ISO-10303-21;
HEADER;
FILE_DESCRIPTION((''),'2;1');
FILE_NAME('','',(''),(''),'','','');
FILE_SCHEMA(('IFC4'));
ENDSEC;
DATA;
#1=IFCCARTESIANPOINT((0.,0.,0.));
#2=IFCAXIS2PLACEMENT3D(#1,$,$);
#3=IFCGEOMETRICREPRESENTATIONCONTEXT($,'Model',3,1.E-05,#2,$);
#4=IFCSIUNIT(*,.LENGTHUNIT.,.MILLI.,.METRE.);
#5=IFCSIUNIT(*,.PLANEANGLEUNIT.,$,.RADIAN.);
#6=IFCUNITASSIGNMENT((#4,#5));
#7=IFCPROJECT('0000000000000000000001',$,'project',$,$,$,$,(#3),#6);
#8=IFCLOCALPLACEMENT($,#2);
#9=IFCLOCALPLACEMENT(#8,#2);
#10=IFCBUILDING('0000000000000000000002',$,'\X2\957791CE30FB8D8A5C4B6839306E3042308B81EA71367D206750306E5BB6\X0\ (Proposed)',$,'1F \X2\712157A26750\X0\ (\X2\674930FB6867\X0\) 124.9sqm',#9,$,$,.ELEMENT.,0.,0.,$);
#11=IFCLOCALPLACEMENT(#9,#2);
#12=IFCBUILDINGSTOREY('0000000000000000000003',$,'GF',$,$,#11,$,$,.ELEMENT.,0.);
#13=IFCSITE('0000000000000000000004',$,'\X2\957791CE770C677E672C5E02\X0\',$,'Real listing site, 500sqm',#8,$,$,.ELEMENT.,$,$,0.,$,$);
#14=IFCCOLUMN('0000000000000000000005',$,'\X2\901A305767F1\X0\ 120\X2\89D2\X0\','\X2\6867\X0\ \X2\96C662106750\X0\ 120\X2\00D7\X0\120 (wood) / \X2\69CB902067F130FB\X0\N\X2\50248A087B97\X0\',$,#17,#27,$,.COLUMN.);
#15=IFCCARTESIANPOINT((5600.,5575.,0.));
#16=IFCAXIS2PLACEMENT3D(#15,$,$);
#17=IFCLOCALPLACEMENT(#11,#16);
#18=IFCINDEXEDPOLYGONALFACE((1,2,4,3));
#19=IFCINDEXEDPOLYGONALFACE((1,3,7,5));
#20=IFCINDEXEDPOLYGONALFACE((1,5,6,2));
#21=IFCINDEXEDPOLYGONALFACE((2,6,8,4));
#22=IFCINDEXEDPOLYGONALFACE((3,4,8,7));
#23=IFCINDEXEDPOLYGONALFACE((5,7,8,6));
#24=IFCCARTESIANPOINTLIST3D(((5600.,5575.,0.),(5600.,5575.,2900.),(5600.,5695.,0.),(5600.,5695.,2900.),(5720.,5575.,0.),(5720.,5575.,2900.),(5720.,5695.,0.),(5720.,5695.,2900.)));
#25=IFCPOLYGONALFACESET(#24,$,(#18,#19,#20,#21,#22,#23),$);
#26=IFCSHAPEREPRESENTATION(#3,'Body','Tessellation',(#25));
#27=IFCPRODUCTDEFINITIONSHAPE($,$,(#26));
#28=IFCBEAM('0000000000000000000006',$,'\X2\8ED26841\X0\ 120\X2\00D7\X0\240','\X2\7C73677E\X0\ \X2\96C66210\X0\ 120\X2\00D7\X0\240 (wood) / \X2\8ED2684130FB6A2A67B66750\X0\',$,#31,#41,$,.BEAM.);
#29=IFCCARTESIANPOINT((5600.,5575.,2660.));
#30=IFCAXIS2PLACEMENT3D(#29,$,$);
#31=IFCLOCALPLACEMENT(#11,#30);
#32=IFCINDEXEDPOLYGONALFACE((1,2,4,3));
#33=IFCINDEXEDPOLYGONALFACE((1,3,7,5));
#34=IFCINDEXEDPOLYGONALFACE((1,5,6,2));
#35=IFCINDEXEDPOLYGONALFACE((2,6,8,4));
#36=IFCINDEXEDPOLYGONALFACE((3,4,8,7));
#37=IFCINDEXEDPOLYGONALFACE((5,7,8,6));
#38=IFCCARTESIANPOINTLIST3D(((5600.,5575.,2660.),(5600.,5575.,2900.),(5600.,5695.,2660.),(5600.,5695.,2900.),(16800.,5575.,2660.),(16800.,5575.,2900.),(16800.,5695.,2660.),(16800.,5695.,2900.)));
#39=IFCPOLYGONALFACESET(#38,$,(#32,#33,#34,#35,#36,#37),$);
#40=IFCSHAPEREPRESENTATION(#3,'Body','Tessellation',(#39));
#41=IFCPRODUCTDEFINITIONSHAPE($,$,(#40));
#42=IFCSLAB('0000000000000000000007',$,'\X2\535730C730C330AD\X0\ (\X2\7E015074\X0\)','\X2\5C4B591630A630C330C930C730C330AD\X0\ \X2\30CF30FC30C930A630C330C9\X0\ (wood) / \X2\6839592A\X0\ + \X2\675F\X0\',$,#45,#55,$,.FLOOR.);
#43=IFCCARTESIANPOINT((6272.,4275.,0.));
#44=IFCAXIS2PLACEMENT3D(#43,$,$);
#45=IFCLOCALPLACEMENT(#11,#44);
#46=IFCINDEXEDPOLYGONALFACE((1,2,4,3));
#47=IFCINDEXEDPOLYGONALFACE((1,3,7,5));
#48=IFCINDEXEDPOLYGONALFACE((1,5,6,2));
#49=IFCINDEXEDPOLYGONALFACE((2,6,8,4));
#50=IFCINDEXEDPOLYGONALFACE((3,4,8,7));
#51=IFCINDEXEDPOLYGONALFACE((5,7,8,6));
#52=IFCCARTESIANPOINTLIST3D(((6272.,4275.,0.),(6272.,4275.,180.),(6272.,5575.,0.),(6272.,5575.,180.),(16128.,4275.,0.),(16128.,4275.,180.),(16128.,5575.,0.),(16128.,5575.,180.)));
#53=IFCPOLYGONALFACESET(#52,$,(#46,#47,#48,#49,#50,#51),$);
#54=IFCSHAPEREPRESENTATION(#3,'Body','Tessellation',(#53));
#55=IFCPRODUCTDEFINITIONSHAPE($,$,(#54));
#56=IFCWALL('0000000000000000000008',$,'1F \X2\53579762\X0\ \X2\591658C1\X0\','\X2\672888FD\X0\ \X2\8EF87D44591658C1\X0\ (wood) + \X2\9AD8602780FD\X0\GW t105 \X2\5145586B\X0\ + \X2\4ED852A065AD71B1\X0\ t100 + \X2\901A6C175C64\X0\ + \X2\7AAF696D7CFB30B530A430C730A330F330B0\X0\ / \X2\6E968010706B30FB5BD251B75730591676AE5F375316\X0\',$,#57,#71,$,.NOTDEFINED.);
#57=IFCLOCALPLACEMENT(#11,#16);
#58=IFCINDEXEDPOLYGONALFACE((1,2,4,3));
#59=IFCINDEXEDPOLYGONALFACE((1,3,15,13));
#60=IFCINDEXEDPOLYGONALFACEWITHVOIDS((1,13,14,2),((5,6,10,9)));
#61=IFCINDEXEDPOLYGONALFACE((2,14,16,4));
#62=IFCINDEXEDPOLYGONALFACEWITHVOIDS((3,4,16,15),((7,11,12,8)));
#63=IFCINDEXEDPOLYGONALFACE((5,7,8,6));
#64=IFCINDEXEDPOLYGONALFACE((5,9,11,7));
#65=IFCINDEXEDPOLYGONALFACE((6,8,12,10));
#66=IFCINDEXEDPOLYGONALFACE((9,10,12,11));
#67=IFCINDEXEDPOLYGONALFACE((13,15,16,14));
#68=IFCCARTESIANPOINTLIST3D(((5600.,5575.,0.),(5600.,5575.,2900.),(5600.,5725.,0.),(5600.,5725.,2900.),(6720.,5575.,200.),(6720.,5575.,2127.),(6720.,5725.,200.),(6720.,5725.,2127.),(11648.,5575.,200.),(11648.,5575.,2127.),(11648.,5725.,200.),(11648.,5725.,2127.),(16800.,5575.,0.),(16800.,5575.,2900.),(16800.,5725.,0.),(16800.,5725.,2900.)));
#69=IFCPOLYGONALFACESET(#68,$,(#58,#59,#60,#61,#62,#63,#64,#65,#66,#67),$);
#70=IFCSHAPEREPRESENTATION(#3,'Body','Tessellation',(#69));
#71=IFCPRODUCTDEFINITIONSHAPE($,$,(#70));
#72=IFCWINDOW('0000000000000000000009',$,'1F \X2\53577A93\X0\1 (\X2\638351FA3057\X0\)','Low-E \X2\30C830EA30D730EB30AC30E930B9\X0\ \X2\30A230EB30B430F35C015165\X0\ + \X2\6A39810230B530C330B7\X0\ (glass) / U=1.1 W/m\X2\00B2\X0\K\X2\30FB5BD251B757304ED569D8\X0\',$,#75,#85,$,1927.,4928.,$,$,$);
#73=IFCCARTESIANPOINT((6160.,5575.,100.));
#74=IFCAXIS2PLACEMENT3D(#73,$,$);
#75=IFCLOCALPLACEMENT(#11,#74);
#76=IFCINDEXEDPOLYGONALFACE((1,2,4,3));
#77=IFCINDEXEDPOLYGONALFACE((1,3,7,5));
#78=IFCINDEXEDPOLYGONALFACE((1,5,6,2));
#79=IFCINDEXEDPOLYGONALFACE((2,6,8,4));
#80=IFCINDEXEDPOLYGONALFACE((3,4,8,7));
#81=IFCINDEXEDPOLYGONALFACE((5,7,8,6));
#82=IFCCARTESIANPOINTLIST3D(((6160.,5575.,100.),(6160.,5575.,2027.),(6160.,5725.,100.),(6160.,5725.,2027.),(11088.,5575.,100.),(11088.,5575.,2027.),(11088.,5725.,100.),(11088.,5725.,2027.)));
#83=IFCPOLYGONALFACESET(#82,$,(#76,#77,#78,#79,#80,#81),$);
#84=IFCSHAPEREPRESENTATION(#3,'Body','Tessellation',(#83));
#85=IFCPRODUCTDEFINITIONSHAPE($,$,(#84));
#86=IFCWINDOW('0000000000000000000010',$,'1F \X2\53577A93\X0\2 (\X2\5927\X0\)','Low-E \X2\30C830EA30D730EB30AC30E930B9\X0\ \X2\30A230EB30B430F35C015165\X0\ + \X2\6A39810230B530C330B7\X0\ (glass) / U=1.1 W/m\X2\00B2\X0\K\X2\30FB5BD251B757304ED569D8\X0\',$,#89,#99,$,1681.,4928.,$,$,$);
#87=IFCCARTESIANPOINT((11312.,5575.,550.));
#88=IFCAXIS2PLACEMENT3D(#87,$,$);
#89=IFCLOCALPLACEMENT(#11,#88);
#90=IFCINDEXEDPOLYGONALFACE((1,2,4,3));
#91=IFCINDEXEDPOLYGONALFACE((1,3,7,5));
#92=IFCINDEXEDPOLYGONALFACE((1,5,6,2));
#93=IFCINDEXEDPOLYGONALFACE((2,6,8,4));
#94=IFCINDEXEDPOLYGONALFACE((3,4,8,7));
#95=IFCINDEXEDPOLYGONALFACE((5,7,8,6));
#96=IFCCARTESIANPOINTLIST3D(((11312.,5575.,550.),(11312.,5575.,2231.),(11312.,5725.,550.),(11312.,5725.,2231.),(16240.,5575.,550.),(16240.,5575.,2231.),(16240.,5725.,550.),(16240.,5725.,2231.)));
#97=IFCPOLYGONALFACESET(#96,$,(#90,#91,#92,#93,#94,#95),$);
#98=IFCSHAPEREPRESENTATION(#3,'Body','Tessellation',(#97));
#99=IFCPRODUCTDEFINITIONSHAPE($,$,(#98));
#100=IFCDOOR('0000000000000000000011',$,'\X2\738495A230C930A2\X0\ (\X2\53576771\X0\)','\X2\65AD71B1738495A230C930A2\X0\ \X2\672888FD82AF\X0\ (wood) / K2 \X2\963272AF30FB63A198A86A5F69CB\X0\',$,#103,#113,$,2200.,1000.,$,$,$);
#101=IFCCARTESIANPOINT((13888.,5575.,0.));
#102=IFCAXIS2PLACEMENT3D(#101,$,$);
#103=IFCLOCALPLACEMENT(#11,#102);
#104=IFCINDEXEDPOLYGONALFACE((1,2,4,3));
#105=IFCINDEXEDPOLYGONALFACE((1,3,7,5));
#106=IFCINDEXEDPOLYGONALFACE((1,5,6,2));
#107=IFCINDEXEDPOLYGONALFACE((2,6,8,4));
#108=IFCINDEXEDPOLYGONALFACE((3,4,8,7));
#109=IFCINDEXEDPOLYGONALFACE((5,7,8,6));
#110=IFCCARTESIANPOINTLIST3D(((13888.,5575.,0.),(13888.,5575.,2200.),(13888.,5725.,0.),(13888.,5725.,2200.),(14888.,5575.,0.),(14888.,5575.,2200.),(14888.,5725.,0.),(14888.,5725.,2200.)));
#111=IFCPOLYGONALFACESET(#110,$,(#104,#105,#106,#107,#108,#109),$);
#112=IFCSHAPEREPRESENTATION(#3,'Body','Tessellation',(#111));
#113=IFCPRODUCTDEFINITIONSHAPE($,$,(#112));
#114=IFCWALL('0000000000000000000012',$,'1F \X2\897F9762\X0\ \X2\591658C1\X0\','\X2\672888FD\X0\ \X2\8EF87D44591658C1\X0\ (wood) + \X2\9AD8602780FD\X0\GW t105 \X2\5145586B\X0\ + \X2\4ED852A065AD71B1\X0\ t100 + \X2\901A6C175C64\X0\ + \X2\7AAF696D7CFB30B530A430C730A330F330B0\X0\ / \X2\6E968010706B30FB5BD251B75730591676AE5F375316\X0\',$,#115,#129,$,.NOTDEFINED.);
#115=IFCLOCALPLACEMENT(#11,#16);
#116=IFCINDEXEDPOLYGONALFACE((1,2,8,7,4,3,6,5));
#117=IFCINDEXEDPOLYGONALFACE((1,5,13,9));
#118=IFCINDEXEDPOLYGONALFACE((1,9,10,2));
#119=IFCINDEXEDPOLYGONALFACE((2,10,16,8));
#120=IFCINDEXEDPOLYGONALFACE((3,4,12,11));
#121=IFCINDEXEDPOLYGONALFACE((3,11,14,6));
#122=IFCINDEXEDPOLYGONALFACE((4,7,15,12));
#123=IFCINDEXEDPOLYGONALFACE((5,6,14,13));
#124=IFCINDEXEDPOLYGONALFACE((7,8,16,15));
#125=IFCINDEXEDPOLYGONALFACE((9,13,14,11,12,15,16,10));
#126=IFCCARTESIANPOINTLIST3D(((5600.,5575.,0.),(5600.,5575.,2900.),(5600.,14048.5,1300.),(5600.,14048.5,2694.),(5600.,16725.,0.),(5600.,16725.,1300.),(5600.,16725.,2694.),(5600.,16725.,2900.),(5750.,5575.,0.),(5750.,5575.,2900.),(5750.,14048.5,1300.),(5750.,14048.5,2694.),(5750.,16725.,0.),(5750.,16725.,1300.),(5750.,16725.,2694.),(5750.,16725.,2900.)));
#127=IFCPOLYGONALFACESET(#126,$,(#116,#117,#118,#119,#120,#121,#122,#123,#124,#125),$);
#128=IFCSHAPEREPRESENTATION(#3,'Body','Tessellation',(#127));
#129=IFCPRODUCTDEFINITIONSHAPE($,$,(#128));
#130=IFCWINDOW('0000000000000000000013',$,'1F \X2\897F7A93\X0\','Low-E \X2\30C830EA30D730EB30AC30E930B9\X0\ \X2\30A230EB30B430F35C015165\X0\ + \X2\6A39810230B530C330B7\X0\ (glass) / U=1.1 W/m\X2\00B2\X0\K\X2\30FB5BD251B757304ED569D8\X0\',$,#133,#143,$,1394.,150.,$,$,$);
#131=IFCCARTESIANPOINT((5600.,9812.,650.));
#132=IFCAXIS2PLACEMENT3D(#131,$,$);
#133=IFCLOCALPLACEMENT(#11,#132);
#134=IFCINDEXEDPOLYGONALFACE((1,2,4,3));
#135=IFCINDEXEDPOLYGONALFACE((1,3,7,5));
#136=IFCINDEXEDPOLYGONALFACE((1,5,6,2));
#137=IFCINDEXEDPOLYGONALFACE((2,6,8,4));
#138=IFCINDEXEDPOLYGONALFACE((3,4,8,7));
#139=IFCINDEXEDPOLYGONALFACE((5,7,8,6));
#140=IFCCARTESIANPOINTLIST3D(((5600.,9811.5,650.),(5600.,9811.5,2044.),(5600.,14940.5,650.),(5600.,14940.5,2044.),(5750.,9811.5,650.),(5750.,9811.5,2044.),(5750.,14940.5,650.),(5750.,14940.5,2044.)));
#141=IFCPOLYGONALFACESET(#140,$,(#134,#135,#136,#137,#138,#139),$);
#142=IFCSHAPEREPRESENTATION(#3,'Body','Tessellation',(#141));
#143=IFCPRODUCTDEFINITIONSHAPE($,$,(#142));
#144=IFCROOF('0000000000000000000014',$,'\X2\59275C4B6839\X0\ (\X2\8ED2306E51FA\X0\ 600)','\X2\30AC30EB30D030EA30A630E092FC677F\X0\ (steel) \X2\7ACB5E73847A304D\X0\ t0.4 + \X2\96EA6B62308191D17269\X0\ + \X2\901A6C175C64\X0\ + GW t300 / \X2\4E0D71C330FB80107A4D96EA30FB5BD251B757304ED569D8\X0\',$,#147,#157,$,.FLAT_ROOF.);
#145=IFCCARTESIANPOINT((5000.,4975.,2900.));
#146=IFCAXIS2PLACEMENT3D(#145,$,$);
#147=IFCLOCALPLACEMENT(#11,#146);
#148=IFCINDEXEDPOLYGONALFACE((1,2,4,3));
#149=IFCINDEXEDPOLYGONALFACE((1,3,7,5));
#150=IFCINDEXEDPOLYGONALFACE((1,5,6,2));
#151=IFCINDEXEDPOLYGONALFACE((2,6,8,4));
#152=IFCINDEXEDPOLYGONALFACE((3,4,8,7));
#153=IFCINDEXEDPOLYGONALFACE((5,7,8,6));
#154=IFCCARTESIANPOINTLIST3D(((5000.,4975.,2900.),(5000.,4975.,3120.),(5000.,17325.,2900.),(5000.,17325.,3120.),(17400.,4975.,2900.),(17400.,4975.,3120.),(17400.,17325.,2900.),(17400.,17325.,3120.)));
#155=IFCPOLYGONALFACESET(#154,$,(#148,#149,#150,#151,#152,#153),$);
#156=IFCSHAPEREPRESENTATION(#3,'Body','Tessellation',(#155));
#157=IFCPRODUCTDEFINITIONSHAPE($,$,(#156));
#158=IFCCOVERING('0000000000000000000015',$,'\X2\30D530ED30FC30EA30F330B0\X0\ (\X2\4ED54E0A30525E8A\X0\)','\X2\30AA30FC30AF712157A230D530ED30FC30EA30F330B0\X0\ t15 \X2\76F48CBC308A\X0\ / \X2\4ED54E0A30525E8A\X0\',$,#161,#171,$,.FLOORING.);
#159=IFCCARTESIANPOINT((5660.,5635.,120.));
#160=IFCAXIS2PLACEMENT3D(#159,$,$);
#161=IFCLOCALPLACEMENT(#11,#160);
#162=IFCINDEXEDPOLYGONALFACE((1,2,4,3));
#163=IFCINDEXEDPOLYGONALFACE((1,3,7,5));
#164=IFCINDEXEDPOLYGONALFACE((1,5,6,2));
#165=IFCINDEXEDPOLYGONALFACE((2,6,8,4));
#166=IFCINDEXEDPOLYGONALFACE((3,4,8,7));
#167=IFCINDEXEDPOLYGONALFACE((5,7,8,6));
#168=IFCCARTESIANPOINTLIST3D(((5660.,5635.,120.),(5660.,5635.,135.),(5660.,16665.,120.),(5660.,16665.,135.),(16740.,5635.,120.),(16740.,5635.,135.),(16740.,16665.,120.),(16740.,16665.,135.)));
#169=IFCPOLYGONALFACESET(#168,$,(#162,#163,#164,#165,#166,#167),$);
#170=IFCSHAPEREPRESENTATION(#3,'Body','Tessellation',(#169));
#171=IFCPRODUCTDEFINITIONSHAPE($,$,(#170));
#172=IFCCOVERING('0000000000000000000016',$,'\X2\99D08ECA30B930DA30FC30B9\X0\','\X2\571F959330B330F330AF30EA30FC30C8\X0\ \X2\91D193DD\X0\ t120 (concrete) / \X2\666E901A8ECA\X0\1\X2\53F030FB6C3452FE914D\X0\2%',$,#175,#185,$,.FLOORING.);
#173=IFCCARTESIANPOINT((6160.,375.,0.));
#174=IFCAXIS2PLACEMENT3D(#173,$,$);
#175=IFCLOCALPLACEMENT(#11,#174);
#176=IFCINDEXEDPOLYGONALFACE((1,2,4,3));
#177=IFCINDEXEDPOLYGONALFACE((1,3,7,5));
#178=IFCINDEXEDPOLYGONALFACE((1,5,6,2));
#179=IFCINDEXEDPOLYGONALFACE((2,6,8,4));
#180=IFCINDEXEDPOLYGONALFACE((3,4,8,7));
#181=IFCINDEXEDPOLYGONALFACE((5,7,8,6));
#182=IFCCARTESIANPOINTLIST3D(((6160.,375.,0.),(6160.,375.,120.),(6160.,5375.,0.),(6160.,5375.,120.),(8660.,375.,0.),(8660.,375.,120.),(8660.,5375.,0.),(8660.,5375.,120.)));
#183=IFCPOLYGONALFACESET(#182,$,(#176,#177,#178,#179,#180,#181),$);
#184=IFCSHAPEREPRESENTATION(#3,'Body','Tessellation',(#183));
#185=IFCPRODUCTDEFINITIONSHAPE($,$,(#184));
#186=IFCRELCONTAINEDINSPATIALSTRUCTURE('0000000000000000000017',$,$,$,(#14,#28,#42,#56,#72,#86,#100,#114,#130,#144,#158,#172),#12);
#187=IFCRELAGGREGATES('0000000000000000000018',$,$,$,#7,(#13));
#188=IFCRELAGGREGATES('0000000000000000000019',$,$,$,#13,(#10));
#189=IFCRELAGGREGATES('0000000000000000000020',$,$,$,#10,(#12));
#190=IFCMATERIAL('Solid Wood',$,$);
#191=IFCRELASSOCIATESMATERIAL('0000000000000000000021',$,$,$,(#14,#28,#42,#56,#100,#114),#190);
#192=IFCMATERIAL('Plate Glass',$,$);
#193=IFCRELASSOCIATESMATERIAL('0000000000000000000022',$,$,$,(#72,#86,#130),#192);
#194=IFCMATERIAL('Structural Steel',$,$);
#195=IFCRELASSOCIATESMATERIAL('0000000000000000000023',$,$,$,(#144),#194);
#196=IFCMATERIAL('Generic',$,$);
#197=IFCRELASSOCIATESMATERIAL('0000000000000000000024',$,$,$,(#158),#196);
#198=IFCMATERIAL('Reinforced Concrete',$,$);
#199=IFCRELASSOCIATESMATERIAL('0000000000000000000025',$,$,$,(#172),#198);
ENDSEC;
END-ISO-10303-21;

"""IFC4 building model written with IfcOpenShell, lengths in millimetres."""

from ifc_helpers import new_model, si_unit, frame, frame_2d, origin, place, context, project, spatial, rectangle, extrude, material, element, fill, save


model = new_model("IFC4")

# Units and contexts
model_context = context("Model", 3, precision=1e-05, world=origin())
ifc_project = project(units=[si_unit("LENGTHUNIT", "METRE", prefix="MILLI"), si_unit("PLANEANGLEUNIT", "RADIAN")], contexts=[model_context])

# Site, building, storey
site_placement = place(None, origin())
site = spatial("IfcSite", under=ifc_project, at=site_placement, Name="長野県松本市", ObjectType="Real listing site, 500sqm", CompositionType="ELEMENT", RefElevation=0.0)
building_placement = place(site_placement, origin())
building = spatial("IfcBuilding", under=site, at=building_placement, Name="長野・越屋根のある自然素材の家 (Proposed)", ObjectType="1F 無垢材 (杉・桧) 124.9sqm", CompositionType="ELEMENT", ElevationOfRefHeight=0.0, ElevationOfTerrain=0.0)
storey_placement = place(building_placement, origin())
storey = spatial("IfcBuildingStorey", under=building, at=storey_placement, Name="GF", CompositionType="ELEMENT", Elevation=0.0)

# Column
ifc_material_1 = material(Name="Solid Wood")
column_1_placement = place(storey_placement, frame((5600.0, 5575.0, 0.0)))
element("IfcColumn", 1, at=column_1_placement, inside=storey, material=ifc_material_1, Name="通し柱 120角", Description="桧 集成材 120×120 (wood) / 構造柱・N値計算", PredefinedType="COLUMN", context=model_context, shape_type="SweptSolid", body=[
    extrude(rectangle(XDim=120.0, YDim=120.0, at=frame_2d((60.0, 60.0))), frame((5600.0, 5575.0, 0.0)), (0.0, 0.0, 1.0), 2900.0),
])

# Beam
beam_1_placement = place(storey_placement, frame((5600.0, 5575.0, 2660.0)))
element("IfcBeam", 2, at=beam_1_placement, inside=storey, material=ifc_material_1, Name="軒桁 120×240", Description="米松 集成 120×240 (wood) / 軒桁・横架材", PredefinedType="BEAM", context=model_context, shape_type="SweptSolid", body=[
    extrude(rectangle(XDim=11200.0, YDim=120.0, at=frame_2d((5600.0, 60.0))), frame((5600.0, 5575.0, 2660.0)), (0.0, 0.0, 1.0), 240.0),
])

# Slab
ifc_material_2 = material(Name="Reinforced Concrete")
slab_1_placement = place(storey_placement, frame((6272.0, 4275.0, 0.0)))
element("IfcSlab", 3, at=slab_1_placement, inside=storey, material=ifc_material_1, Name="南デッキ (縁側)", Description="屋外ウッドデッキ ハードウッド (wood) / 根太 + 束", PredefinedType="FLOOR", context=model_context, shape_type="SweptSolid", body=[
    extrude(rectangle(XDim=9856.0, YDim=1300.0, at=frame_2d((4928.0, 650.0))), frame((6272.0, 4275.0, 0.0)), (0.0, 0.0, 1.0), 180.0),
])

# Wall, openings, windows, door
wall_1_placement = place(storey_placement, frame((5600.0, 5575.0, 0.0)))
wall_1 = element("IfcWall", 4, at=wall_1_placement, inside=storey, material=ifc_material_1, Name="1F 南面 外壁", Description="木製 軸組外壁 (wood) + 高性能GW t105 充填 + 付加断熱 t100 + 通気層 + 窯業系サイディング / 準耐火・寒冷地外皮強化", PredefinedType="NOTDEFINED", context=model_context, shape_type="SweptSolid", body=[
    extrude(rectangle(XDim=11200.0, YDim=150.0, at=frame_2d((5600.0, 75.0))), frame((5600.0, 5575.0, 0.0)), (0.0, 0.0, 1.0), 2900.0),
])
opening_1_placement = place(storey_placement, frame((6160.0, 5575.0, 100.0)))
opening_1 = element("IfcOpeningElement", 5, at=opening_1_placement, cuts=wall_1, PredefinedType="NOTDEFINED", context=model_context, shape_type="SweptSolid", body=[
    extrude(rectangle(XDim=4928.0, YDim=150.0, at=frame_2d((2464.0, 75.0))), frame((6160.0, 5575.0, 100.0)), (0.0, 0.0, 1.0), 1927.0),
])
opening_2_placement = place(storey_placement, frame((11312.0, 5575.0, 550.0)))
opening_2 = element("IfcOpeningElement", 6, at=opening_2_placement, cuts=wall_1, PredefinedType="NOTDEFINED", context=model_context, shape_type="SweptSolid", body=[
    extrude(rectangle(XDim=4928.0, YDim=150.0, at=frame_2d((2464.0, 75.0))), frame((11312.0, 5575.0, 550.0)), (0.0, 0.0, 1.0), 1681.0),
])
opening_3_placement = place(storey_placement, frame((13888.0, 5575.0, 0.0)))
opening_3 = element("IfcOpeningElement", 7, at=opening_3_placement, cuts=wall_1, PredefinedType="NOTDEFINED", context=model_context, shape_type="SweptSolid", body=[
    extrude(rectangle(XDim=1000.0, YDim=150.0, at=frame_2d((500.0, 75.0))), frame((13888.0, 5575.0, 0.0)), (0.0, 0.0, 1.0), 2200.0),
])
ifc_material_3 = material(Name="Plate Glass")
window_1_placement = place(storey_placement, frame((6160.0, 5575.0, 100.0)))
window_1 = element("IfcWindow", 8, at=window_1_placement, inside=storey, material=ifc_material_3, Name="1F 南窓1 (掃出し)", Description="Low-E トリプルガラス アルゴン封入 + 樹脂サッシ (glass) / U=1.1 W/m²K・寒冷地仕様", OverallHeight=1927.0, OverallWidth=4928.0, context=model_context, shape_type="SweptSolid", body=[
    extrude(rectangle(XDim=4928.0, YDim=150.0, at=frame_2d((2464.0, 75.0))), frame((6160.0, 5575.0, 100.0)), (0.0, 0.0, 1.0), 1927.0),
])
fill(opening_1, window_1)
window_2_placement = place(storey_placement, frame((11312.0, 5575.0, 550.0)))
window_2 = element("IfcWindow", 9, at=window_2_placement, inside=storey, material=ifc_material_3, Name="1F 南窓2 (大)", Description="Low-E トリプルガラス アルゴン封入 + 樹脂サッシ (glass) / U=1.1 W/m²K・寒冷地仕様", OverallHeight=1681.0, OverallWidth=4928.0, context=model_context, shape_type="SweptSolid", body=[
    extrude(rectangle(XDim=4928.0, YDim=150.0, at=frame_2d((2464.0, 75.0))), frame((11312.0, 5575.0, 550.0)), (0.0, 0.0, 1.0), 1681.0),
])
fill(opening_2, window_2)
door_placement = place(storey_placement, frame((13888.0, 5575.0, 0.0)))
door = element("IfcDoor", 10, at=door_placement, inside=storey, material=ifc_material_1, Name="玄関ドア (南東)", Description="断熱玄関ドア 木製芯 (wood) / K2 防犯・採風機構", OverallHeight=2200.0, OverallWidth=1000.0, context=model_context, shape_type="SweptSolid", body=[
    extrude(rectangle(XDim=1000.0, YDim=150.0, at=frame_2d((500.0, 75.0))), frame((13888.0, 5575.0, 0.0)), (0.0, 0.0, 1.0), 2200.0),
])
fill(opening_3, door)

# Wall, opening, window
wall_2_placement = place(storey_placement, frame((5600.0, 5575.0, 0.0)))
wall_2 = element("IfcWall", 11, at=wall_2_placement, inside=storey, material=ifc_material_1, Name="1F 西面 外壁", Description="木製 軸組外壁 (wood) + 高性能GW t105 充填 + 付加断熱 t100 + 通気層 + 窯業系サイディング / 準耐火・寒冷地外皮強化", PredefinedType="NOTDEFINED", context=model_context, shape_type="SweptSolid", body=[
    extrude(rectangle(XDim=150.0, YDim=11150.0, at=frame_2d((75.0, 5575.0))), frame((5600.0, 5575.0, 0.0)), (0.0, 0.0, 1.0), 2900.0),
])
opening_4_placement = place(storey_placement, frame((5600.0, 9812.0, 650.0)))
opening_4 = element("IfcOpeningElement", 12, at=opening_4_placement, cuts=wall_2, PredefinedType="NOTDEFINED", context=model_context, shape_type="SweptSolid", body=[
    extrude(rectangle(XDim=150.0, YDim=5129.0, at=frame_2d((75.0, 2564.0))), frame((5600.0, 9812.0, 650.0)), (0.0, 0.0, 1.0), 1394.0),
])
window_3_placement = place(storey_placement, frame((5600.0, 9812.0, 650.0)))
window_3 = element("IfcWindow", 13, at=window_3_placement, inside=storey, material=ifc_material_3, Name="1F 西窓", Description="Low-E トリプルガラス アルゴン封入 + 樹脂サッシ (glass) / U=1.1 W/m²K・寒冷地仕様", OverallHeight=1394.0, OverallWidth=150.0, context=model_context, shape_type="SweptSolid", body=[
    extrude(rectangle(XDim=150.0, YDim=5129.0, at=frame_2d((75.0, 2564.0))), frame((5600.0, 9812.0, 650.0)), (0.0, 0.0, 1.0), 1394.0),
])
fill(opening_4, window_3)

# Roof
ifc_material_4 = material(Name="Structural Steel")
roof_placement = place(storey_placement, frame((5000.0, 4975.0, 2900.0)))
element("IfcRoof", 14, at=roof_placement, inside=storey, material=ifc_material_4, Name="大屋根 (軒の出 600)", Description="ガルバリウム鋼板 (steel) 立平葺き t0.4 + 雪止め金物 + 通気層 + GW t300 / 不燃・耐積雪・寒冷地仕様", PredefinedType="FLAT_ROOF", context=model_context, shape_type="SweptSolid", body=[
    extrude(rectangle(XDim=12400.0, YDim=12350.0, at=frame_2d((6200.0, 6175.0))), frame((5000.0, 4975.0, 2900.0)), (0.0, 0.0, 1.0), 220.0),
])

# Coverings
ifc_material_5 = material(Name="Generic")
covering_1_placement = place(storey_placement, frame((5660.0, 5635.0, 120.0)))
element("IfcCovering", 15, at=covering_1_placement, inside=storey, material=ifc_material_5, Name="フローリング (仕上げ床)", Description="オーク無垢フローリング t15 直貼り / 仕上げ床", PredefinedType="FLOORING", context=model_context, shape_type="SweptSolid", body=[
    extrude(rectangle(XDim=11080.0, YDim=11030.0, at=frame_2d((5540.0, 5515.0))), frame((5660.0, 5635.0, 120.0)), (0.0, 0.0, 1.0), 15.0),
])
covering_2_placement = place(storey_placement, frame((6160.0, 375.0, 0.0)))
element("IfcCovering", 16, at=covering_2_placement, inside=storey, material=ifc_material_2, Name="駐車スペース", Description="土間コンクリート 金鏝 t120 (concrete) / 普通車1台・水勾配2%", PredefinedType="FLOORING", context=model_context, shape_type="SweptSolid", body=[
    extrude(rectangle(XDim=2500.0, YDim=5000.0, at=frame_2d((1250.0, 2500.0))), frame((6160.0, 375.0, 0.0)), (0.0, 0.0, 1.0), 120.0),
])

save(model, "model.ifc")
